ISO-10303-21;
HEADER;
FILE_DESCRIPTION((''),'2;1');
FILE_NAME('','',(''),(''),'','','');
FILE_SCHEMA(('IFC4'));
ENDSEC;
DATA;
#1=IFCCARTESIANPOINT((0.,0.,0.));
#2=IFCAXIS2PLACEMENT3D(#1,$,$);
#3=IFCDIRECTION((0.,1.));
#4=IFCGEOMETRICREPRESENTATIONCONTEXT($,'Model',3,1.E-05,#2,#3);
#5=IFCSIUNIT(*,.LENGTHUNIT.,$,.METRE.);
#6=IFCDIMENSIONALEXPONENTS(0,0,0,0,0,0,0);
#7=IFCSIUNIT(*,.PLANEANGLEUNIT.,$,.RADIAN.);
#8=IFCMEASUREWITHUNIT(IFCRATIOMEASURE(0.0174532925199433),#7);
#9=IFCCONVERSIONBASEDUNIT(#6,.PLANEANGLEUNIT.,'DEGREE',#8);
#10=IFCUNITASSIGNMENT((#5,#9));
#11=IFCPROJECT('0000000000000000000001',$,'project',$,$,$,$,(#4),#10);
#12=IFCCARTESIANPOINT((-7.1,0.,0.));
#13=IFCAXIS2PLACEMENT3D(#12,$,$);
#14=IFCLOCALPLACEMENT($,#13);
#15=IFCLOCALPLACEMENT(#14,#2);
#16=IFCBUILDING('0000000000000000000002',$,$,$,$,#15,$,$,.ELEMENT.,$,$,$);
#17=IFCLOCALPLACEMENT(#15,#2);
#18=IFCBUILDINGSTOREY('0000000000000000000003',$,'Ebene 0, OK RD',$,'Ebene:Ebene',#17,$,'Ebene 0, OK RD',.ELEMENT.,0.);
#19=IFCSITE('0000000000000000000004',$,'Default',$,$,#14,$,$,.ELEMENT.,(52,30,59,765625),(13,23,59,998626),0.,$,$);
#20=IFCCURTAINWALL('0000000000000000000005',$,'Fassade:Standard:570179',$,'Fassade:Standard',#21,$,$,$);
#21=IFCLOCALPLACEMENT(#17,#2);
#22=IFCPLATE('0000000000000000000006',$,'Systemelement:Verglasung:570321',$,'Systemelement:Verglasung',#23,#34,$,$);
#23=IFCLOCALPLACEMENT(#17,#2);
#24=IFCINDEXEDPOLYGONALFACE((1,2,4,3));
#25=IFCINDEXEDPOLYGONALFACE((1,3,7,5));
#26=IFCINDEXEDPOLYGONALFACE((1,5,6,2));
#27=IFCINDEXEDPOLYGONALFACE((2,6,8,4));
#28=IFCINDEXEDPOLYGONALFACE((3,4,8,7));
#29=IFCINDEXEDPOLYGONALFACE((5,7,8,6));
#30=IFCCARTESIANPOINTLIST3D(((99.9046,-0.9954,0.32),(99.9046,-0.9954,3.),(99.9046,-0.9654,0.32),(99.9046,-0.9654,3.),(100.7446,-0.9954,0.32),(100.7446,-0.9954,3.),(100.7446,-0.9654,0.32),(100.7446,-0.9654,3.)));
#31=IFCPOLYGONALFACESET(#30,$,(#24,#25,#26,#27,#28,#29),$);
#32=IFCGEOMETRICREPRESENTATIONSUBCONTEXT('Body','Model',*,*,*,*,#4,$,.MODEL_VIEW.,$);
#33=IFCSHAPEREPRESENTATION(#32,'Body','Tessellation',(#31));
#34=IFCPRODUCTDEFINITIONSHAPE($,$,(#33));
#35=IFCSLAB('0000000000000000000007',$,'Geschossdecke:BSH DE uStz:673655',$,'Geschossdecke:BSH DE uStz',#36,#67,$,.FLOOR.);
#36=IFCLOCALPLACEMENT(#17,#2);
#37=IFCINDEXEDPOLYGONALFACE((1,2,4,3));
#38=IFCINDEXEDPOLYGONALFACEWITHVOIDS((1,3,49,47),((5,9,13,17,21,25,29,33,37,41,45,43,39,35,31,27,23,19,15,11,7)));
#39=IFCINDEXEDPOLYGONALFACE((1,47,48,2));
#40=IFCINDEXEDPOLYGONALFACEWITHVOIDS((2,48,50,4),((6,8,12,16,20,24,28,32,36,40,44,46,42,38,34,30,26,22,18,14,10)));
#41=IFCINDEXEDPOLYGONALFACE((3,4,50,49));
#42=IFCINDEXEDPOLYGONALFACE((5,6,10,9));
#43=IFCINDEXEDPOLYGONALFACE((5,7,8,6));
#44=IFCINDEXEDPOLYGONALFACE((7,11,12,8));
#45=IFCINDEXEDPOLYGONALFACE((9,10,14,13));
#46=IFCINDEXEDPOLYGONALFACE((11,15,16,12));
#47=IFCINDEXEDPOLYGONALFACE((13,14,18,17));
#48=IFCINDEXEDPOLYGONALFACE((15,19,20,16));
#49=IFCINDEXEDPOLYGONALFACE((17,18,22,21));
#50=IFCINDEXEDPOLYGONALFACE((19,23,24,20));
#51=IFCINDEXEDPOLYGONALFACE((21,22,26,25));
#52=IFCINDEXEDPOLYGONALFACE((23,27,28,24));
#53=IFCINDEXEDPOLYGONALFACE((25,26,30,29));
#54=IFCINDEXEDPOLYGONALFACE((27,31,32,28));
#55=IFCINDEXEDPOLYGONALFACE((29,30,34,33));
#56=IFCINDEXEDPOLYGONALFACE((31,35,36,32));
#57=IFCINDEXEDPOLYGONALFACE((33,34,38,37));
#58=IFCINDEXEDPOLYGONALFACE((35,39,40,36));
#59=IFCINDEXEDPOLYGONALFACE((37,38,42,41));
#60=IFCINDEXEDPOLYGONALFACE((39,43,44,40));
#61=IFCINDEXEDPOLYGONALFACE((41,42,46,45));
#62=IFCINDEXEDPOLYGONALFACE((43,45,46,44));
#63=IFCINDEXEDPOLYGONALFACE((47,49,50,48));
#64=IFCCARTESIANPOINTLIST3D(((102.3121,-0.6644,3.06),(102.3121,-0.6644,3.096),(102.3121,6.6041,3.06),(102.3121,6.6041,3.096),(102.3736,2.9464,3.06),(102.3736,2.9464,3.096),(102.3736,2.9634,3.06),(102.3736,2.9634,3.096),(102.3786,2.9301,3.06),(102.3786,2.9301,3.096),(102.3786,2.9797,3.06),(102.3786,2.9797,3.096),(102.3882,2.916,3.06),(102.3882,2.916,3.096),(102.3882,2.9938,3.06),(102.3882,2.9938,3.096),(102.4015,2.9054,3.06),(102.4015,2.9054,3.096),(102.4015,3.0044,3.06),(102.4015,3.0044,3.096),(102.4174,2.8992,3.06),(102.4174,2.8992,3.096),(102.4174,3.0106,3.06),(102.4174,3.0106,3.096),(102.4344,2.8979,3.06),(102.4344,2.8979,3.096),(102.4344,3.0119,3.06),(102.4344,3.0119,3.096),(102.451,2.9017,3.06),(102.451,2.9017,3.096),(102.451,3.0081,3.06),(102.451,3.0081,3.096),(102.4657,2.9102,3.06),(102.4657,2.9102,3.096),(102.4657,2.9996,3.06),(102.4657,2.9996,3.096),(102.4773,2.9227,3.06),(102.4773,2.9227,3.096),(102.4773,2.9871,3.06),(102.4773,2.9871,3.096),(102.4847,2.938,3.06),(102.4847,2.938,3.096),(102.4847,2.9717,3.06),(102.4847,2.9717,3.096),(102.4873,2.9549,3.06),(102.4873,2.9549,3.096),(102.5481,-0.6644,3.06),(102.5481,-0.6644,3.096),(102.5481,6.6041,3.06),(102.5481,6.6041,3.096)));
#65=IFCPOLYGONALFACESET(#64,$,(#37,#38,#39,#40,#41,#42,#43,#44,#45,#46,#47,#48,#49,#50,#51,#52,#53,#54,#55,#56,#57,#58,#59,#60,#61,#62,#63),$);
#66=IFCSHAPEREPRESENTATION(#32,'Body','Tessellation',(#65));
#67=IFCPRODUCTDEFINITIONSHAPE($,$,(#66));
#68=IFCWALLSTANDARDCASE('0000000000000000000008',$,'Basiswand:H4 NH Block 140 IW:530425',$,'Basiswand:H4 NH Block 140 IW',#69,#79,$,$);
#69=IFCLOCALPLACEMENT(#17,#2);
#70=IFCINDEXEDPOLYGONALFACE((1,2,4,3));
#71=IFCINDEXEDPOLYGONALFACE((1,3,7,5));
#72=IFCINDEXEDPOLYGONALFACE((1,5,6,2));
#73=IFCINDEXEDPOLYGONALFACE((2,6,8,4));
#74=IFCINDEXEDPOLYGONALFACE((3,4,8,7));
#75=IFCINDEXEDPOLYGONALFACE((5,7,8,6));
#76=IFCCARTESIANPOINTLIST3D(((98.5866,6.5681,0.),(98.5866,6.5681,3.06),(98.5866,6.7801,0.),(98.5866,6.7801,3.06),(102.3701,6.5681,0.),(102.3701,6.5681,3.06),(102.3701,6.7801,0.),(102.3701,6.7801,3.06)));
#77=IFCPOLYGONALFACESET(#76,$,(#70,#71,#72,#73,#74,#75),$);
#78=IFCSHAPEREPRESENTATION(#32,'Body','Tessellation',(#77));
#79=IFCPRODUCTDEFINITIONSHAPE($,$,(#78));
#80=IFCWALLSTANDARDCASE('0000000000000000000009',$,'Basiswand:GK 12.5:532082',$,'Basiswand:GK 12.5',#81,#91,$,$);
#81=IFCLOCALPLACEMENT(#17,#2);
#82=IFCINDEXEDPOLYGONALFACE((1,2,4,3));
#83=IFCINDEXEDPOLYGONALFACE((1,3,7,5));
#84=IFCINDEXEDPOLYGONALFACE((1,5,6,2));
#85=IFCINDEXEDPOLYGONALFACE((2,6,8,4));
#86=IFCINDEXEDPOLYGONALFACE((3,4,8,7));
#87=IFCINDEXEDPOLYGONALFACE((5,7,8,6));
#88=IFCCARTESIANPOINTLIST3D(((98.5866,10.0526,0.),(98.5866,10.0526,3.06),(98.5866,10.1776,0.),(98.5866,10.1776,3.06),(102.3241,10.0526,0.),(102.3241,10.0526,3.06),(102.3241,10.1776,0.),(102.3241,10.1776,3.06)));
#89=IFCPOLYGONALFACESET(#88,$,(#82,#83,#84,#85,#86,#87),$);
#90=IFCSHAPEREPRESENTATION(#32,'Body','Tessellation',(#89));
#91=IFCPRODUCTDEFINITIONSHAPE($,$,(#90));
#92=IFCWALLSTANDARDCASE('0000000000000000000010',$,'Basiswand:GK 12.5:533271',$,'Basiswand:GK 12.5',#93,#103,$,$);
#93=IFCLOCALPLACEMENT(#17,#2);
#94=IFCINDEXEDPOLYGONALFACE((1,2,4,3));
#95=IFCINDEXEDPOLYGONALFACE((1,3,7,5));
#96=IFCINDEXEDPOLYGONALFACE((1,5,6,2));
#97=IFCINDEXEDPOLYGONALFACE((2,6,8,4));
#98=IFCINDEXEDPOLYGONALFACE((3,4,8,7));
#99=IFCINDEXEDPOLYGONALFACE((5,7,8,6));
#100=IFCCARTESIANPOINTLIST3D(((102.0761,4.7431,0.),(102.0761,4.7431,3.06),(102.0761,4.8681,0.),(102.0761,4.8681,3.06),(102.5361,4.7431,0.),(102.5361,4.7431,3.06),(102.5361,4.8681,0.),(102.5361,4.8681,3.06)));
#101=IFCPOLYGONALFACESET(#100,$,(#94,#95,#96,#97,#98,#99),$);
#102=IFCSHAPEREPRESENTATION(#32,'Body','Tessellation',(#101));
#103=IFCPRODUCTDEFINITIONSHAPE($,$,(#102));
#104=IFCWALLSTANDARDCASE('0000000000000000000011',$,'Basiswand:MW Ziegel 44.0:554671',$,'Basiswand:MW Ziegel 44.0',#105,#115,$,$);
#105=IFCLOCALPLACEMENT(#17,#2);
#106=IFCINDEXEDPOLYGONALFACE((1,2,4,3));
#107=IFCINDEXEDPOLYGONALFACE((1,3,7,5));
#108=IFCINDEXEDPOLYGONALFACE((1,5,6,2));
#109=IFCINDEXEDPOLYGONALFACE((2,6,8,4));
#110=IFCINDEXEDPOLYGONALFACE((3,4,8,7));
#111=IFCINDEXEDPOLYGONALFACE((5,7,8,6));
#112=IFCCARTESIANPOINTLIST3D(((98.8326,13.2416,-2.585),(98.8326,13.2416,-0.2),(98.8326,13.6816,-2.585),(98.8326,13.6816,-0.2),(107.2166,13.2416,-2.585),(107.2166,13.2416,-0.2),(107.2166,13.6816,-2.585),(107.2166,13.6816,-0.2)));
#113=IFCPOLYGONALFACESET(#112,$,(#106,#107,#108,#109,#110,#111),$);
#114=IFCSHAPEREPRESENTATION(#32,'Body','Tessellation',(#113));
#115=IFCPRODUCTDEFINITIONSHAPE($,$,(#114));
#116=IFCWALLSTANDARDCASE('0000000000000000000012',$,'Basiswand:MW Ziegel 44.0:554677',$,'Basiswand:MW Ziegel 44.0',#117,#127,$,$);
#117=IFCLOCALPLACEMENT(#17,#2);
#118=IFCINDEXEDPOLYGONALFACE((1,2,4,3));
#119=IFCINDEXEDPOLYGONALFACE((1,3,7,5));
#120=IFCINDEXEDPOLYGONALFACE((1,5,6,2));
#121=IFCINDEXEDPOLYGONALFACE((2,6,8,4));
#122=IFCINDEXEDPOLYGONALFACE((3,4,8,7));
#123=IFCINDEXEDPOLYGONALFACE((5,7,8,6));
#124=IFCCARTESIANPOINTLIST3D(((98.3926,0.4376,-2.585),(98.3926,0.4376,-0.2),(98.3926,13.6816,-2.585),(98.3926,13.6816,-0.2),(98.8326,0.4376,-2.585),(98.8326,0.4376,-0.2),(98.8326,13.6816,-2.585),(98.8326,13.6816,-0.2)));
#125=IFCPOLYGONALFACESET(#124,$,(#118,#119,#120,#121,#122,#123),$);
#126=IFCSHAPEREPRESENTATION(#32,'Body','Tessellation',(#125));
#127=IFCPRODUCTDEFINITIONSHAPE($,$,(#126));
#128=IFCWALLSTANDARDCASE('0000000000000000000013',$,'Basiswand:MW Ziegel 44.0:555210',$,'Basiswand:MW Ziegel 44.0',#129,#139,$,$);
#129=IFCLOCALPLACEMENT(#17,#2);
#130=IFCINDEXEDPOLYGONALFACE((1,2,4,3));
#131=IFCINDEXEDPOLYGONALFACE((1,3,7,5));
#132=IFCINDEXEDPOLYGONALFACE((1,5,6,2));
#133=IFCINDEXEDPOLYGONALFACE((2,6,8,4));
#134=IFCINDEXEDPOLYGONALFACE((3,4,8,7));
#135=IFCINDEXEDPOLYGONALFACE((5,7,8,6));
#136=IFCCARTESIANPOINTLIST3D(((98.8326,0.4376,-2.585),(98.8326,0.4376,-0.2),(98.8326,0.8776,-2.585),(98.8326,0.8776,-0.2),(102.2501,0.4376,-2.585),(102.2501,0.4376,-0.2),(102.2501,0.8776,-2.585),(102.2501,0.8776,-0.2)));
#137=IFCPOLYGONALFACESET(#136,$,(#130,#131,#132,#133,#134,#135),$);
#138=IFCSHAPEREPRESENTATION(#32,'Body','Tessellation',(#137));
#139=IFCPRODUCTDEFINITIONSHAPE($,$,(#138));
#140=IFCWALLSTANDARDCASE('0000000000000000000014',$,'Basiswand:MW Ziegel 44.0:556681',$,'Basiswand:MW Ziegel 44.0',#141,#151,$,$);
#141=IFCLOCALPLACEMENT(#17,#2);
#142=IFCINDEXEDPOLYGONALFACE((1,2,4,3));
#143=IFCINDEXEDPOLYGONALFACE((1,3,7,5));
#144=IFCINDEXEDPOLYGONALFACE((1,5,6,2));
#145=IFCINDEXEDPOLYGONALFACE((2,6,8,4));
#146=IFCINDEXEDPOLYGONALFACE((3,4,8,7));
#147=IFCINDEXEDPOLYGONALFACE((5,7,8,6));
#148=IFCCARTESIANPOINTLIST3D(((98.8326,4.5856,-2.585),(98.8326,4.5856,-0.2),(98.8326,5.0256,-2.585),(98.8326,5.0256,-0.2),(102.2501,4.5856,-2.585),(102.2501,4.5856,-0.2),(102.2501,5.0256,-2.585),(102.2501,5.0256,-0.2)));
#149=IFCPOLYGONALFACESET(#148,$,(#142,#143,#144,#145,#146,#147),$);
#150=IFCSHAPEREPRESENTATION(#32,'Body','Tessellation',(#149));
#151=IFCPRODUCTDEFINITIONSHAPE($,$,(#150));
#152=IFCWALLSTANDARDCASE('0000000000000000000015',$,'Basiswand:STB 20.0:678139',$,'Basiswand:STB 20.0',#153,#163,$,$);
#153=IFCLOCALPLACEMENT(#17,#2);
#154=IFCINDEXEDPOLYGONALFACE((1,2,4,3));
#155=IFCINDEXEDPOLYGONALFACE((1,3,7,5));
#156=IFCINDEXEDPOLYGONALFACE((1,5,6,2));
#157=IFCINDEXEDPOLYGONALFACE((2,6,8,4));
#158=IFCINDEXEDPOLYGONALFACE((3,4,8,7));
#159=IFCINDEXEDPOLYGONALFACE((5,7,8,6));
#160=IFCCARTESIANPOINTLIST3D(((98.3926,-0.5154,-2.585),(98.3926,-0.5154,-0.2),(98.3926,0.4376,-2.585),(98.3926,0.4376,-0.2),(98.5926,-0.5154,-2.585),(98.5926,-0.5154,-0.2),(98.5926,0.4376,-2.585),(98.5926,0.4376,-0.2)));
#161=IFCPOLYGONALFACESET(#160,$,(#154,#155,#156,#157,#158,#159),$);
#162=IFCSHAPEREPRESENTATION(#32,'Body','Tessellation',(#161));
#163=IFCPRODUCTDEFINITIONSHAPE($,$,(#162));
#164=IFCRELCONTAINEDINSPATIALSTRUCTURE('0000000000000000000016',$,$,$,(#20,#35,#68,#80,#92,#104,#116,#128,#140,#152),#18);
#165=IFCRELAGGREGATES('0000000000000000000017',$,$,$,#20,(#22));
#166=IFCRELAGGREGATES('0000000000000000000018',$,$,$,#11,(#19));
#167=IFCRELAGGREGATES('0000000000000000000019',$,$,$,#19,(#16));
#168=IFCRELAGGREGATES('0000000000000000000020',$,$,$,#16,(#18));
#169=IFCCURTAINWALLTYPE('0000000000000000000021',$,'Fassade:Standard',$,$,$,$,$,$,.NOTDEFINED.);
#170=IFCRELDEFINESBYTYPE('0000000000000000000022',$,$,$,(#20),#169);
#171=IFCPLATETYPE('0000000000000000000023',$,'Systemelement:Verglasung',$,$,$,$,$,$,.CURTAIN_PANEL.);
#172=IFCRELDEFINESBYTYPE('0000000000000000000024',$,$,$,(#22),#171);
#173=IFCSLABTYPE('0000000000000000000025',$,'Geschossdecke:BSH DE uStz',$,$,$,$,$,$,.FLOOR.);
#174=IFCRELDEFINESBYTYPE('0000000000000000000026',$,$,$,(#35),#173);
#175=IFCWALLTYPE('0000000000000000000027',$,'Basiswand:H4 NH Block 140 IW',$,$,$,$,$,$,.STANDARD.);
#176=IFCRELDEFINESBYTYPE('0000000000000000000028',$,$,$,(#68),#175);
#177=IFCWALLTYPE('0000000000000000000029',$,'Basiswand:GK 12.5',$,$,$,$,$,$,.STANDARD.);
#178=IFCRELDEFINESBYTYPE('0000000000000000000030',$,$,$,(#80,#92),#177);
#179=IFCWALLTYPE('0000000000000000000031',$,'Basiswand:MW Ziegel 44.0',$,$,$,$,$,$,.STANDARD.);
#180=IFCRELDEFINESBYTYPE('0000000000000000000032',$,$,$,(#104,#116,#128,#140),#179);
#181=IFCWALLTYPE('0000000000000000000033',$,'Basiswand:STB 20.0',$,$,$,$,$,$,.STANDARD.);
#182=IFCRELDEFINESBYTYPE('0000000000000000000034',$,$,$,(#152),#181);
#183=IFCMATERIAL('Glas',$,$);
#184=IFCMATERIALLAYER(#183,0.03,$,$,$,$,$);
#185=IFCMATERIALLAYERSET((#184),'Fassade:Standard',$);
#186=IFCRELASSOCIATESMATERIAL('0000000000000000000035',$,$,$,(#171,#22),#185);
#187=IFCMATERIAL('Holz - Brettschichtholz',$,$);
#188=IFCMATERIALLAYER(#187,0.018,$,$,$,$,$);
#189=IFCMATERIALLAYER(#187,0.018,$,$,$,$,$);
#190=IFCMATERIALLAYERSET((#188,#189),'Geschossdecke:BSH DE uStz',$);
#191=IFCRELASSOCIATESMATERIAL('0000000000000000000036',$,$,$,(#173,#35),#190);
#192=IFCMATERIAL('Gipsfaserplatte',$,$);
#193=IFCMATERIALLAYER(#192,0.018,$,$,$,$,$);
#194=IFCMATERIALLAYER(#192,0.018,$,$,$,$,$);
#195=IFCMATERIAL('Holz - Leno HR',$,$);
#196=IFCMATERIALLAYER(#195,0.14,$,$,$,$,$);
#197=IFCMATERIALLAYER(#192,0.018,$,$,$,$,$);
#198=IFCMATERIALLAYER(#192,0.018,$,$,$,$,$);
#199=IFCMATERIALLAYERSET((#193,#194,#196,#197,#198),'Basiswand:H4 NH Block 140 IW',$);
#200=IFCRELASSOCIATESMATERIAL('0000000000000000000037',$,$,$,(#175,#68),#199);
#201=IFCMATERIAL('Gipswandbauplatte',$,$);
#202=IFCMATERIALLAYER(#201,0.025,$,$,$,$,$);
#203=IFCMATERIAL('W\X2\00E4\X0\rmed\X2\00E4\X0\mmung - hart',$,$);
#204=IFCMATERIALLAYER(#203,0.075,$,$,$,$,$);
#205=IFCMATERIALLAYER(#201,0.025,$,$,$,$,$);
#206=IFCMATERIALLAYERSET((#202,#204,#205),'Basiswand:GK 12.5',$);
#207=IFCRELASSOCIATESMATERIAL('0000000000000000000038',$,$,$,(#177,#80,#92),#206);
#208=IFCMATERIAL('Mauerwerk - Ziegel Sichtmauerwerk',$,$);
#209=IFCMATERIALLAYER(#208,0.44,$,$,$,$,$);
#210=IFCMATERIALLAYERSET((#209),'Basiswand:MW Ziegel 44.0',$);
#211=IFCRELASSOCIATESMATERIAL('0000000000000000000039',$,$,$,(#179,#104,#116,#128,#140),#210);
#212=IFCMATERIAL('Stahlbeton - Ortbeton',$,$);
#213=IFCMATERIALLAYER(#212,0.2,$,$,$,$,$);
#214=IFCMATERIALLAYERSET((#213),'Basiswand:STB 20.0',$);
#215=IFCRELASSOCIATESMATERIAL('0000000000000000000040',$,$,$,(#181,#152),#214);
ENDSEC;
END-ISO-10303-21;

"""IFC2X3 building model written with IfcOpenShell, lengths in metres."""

from ifc_helpers import new_model, entity, si_unit, converted_unit, direction, frame, frame_2d, origin, origin_2d_with_axis, place, context, subcontext, project, spatial, rectangle, circle, extrude, source, transform, mapped, material, layer, layer_set, layer_usage, type_object, type_shapes, element, aggregate, save


model = new_model("IFC2X3")

# Units and contexts
model_context = context("Model", 3, precision=1e-05, world=origin(), true_north=direction((0.0, 1.0)))
body_context = subcontext(model_context, "Body", "Model", "MODEL_VIEW")
ifc_project = project(units=[si_unit("LENGTHUNIT", "METRE"), converted_unit("PLANEANGLEUNIT", "DEGREE", entity("IfcRatioMeasure", 0.0174532925199433), si_unit("PLANEANGLEUNIT", "RADIAN"), dimensions=[0, 0, 0, 0, 0, 0, 0])], contexts=[model_context])

# Site, building, storey
site_placement = place(None, frame((-7.1, 0.0, 0.0)))
site = spatial("IfcSite", under=ifc_project, at=site_placement, Name="Default", CompositionType="ELEMENT", RefLatitude=(52, 30, 59, 765625), RefLongitude=(13, 23, 59, 998626), RefElevation=0.0)
building_placement = place(site_placement, origin())
building = spatial("IfcBuilding", under=site, at=building_placement, CompositionType="ELEMENT")
storey_placement = place(building_placement, origin())
storey = spatial("IfcBuildingStorey", under=building, at=storey_placement, Name="Ebene 0, OK RD", ObjectType="Ebene:Ebene", LongName="Ebene 0, OK RD", CompositionType="ELEMENT", Elevation=0.0)

# Curtain wall, plate
curtain_wall_type = type_object("IfcCurtainWallType", Name="Fassade:Standard", PredefinedType="NOTDEFINED")
curtain_wall_placement = place(storey_placement, origin())
curtain_wall = element("IfcCurtainWall", 1, at=curtain_wall_placement, inside=storey, type_object=curtain_wall_type, Name="Fassade:Standard:570179", ObjectType="Fassade:Standard")
ifc_material_1 = material(Name="Glas")
ifc_layer_1 = layer(ifc_material_1, 0.03)
ifc_layer_set_1 = layer_set([ifc_layer_1], Name="Fassade:Standard")
ifc_layer_usage_1 = layer_usage(ifc_layer_set_1, "AXIS3", "POSITIVE", 0.0)
plate_type_1 = type_object("IfcPlateType", Name="Systemelement:Verglasung", PredefinedType="CURTAIN_PANEL", material=ifc_layer_set_1)
shared_shape_1 = source(origin(), body_context, "Body", "SweptSolid", [
    extrude(rectangle(XDim=0.03, YDim=0.84, at=origin_2d_with_axis()), frame((0.0, 0.0, 0.0), z_axis=(0.0, 0.0, 1.0), x_axis=(0.0, 1.0, 0.0)), (0.0, 0.0, 1.0), 2.68),
])
type_shapes(plate_type_1, [shared_shape_1])
plate_1_placement = place(curtain_wall_placement, frame((100.3246, -0.9804, 0.32)))
plate_1 = element("IfcPlate", 2, at=plate_1_placement, type_object=plate_type_1, material=ifc_layer_usage_1, Name="Systemelement:Verglasung:570321", ObjectType="Systemelement:Verglasung", context=body_context, shape_type="MappedRepresentation", body=[
    mapped(shared_shape_1, transform((0.0, 0.0, 0.0), scale=1.0)),
])
aggregate(curtain_wall, [plate_1])

# Slab, opening
ifc_material_2 = material(Name="Holz - Brettschichtholz")
ifc_layer_2 = layer(ifc_material_2, 0.018)
ifc_layer_3 = layer(ifc_material_2, 0.018)
ifc_layer_set_2 = layer_set([ifc_layer_2, ifc_layer_3], Name="Geschossdecke:BSH DE uStz")
ifc_layer_usage_2 = layer_usage(ifc_layer_set_2, "AXIS3", "POSITIVE", 0.0)
slab_type_1 = type_object("IfcSlabType", Name="Geschossdecke:BSH DE uStz", PredefinedType="FLOOR", material=ifc_layer_set_2)
slab_placement = place(storey_placement, frame((102.3121, -0.6644, 3.06)))
slab = element("IfcSlab", 3, at=slab_placement, inside=storey, type_object=slab_type_1, material=ifc_layer_usage_2, Name="Geschossdecke:BSH DE uStz:673655", ObjectType="Geschossdecke:BSH DE uStz", PredefinedType="FLOOR", context=body_context, shape_type="SweptSolid", body=[
    extrude(rectangle(XDim=0.236, YDim=7.2685, at=origin_2d_with_axis()), frame((0.118, 3.6343, 0.036), z_axis=(0.0, 0.0, -1.0), x_axis=(-1.0, 0.0, 0.0)), (0.0, 0.0, 1.0), 0.036),
])
opening_1_placement = place(slab_placement, frame((0.118, 3.6193, 0.036)))
element("IfcOpeningElement", 4, at=opening_1_placement, cuts=slab, ObjectType="Opening", context=body_context, shape_type="SweptSolid", body=[
    extrude(circle(Radius=0.0571, at=origin_2d_with_axis()), frame((0.0, 0.0, 0.0), z_axis=(0.0, 0.0, -1.0), x_axis=(1.0, 0.0, 0.0)), (0.0, 0.0, 1.0), 0.036),
])

# Walls
ifc_material_3 = material(Name="Gipsfaserplatte")
ifc_layer_4 = layer(ifc_material_3, 0.018)
ifc_layer_5 = layer(ifc_material_3, 0.018)
ifc_material_4 = material(Name="Holz - Leno HR")
ifc_layer_6 = layer(ifc_material_4, 0.14)
ifc_layer_7 = layer(ifc_material_3, 0.018)
ifc_layer_8 = layer(ifc_material_3, 0.018)
ifc_layer_set_3 = layer_set([ifc_layer_4, ifc_layer_5, ifc_layer_6, ifc_layer_7, ifc_layer_8], Name="Basiswand:H4 NH Block 140 IW")
ifc_layer_usage_3 = layer_usage(ifc_layer_set_3, "AXIS2", "NEGATIVE", 0.106)
wall_type_1 = type_object("IfcWallType", Name="Basiswand:H4 NH Block 140 IW", PredefinedType="STANDARD", material=ifc_layer_set_3)
wall_1_placement = place(storey_placement, frame((98.5866, 6.6741, 0.0)))
element("IfcWallStandardCase", 5, at=wall_1_placement, inside=storey, type_object=wall_type_1, material=ifc_layer_usage_3, Name="Basiswand:H4 NH Block 140 IW:530425", ObjectType="Basiswand:H4 NH Block 140 IW", context=body_context, shape_type="SweptSolid", body=[
    extrude(rectangle(XDim=3.7835, YDim=0.212, at=frame_2d((1.8918, 0.0), x_axis=(-1.0, 0.0))), origin(), (0.0, 0.0, 1.0), 3.06),
])
ifc_material_5 = material(Name="Gipswandbauplatte")
ifc_layer_9 = layer(ifc_material_5, 0.025)
ifc_material_6 = material(Name="Wärmedämmung - hart")
ifc_layer_10 = layer(ifc_material_6, 0.075)
ifc_layer_11 = layer(ifc_material_5, 0.025)
ifc_layer_set_4 = layer_set([ifc_layer_9, ifc_layer_10, ifc_layer_11], Name="Basiswand:GK 12.5")
ifc_layer_usage_4 = layer_usage(ifc_layer_set_4, "AXIS2", "NEGATIVE", 0.0625)
wall_type_2 = type_object("IfcWallType", Name="Basiswand:GK 12.5", PredefinedType="STANDARD", material=ifc_layer_set_4)
wall_2_placement = place(storey_placement, frame((98.5866, 10.1151, 0.0)))
element("IfcWallStandardCase", 6, at=wall_2_placement, inside=storey, type_object=wall_type_2, material=ifc_layer_usage_4, Name="Basiswand:GK 12.5:532082", ObjectType="Basiswand:GK 12.5", context=body_context, shape_type="SweptSolid", body=[
    extrude(rectangle(XDim=3.7375, YDim=0.125, at=frame_2d((1.8687, 0.0), x_axis=(-1.0, 0.0))), origin(), (0.0, 0.0, 1.0), 3.06),
])
ifc_layer_usage_5 = layer_usage(ifc_layer_set_4, "AXIS2", "NEGATIVE", 0.0625)
wall_3_placement = place(storey_placement, frame((102.0761, 4.8056, 0.0)))
element("IfcWallStandardCase", 7, at=wall_3_placement, inside=storey, type_object=wall_type_2, material=ifc_layer_usage_5, Name="Basiswand:GK 12.5:533271", ObjectType="Basiswand:GK 12.5", context=body_context, shape_type="SweptSolid", body=[
    extrude(rectangle(XDim=0.46, YDim=0.125, at=frame_2d((0.23, 0.0), x_axis=(-1.0, 0.0))), origin(), (0.0, 0.0, 1.0), 3.06),
])
ifc_material_7 = material(Name="Mauerwerk - Ziegel Sichtmauerwerk")
ifc_layer_12 = layer(ifc_material_7, 0.44)
ifc_layer_set_5 = layer_set([ifc_layer_12], Name="Basiswand:MW Ziegel 44.0")
ifc_layer_usage_6 = layer_usage(ifc_layer_set_5, "AXIS2", "NEGATIVE", 0.22)
wall_type_3 = type_object("IfcWallType", Name="Basiswand:MW Ziegel 44.0", PredefinedType="STANDARD", material=ifc_layer_set_5)
wall_4_placement = place(storey_placement, frame((98.8326, 13.4616, -2.585)))
element("IfcWallStandardCase", 8, at=wall_4_placement, inside=storey, type_object=wall_type_3, material=ifc_layer_usage_6, Name="Basiswand:MW Ziegel 44.0:554671", ObjectType="Basiswand:MW Ziegel 44.0", context=body_context, shape_type="SweptSolid", body=[
    extrude(rectangle(XDim=8.384, YDim=0.44, at=frame_2d((4.192, 0.0), x_axis=(-1.0, 0.0))), origin(), (0.0, 0.0, 1.0), 2.385),
])
ifc_layer_usage_7 = layer_usage(ifc_layer_set_5, "AXIS2", "NEGATIVE", 0.22)
wall_5_placement = place(storey_placement, frame((98.6126, 0.4376, -2.585), z_axis=(0.0, 0.0, 1.0), x_axis=(0.0, 1.0, 0.0)))
element("IfcWallStandardCase", 9, at=wall_5_placement, inside=storey, type_object=wall_type_3, material=ifc_layer_usage_7, Name="Basiswand:MW Ziegel 44.0:554677", ObjectType="Basiswand:MW Ziegel 44.0", context=body_context, shape_type="SweptSolid", body=[
    extrude(rectangle(XDim=13.244, YDim=0.44, at=frame_2d((6.622, 0.0), x_axis=(-1.0, 0.0))), origin(), (0.0, 0.0, 1.0), 2.385),
])
ifc_layer_usage_8 = layer_usage(ifc_layer_set_5, "AXIS2", "NEGATIVE", 0.22)
wall_6_placement = place(storey_placement, frame((102.2501, 0.6576, -2.585), z_axis=(0.0, 0.0, 1.0), x_axis=(-1.0, 0.0, 0.0)))
element("IfcWallStandardCase", 10, at=wall_6_placement, inside=storey, type_object=wall_type_3, material=ifc_layer_usage_8, Name="Basiswand:MW Ziegel 44.0:555210", ObjectType="Basiswand:MW Ziegel 44.0", context=body_context, shape_type="SweptSolid", body=[
    extrude(rectangle(XDim=3.4175, YDim=0.44, at=frame_2d((1.7087, 0.0), x_axis=(-1.0, 0.0))), origin(), (0.0, 0.0, 1.0), 2.385),
])
ifc_layer_usage_9 = layer_usage(ifc_layer_set_5, "AXIS2", "NEGATIVE", 0.22)
wall_7_placement = place(storey_placement, frame((98.8326, 4.8056, -2.585)))
element("IfcWallStandardCase", 11, at=wall_7_placement, inside=storey, type_object=wall_type_3, material=ifc_layer_usage_9, Name="Basiswand:MW Ziegel 44.0:556681", ObjectType="Basiswand:MW Ziegel 44.0", context=body_context, shape_type="SweptSolid", body=[
    extrude(rectangle(XDim=3.4175, YDim=0.44, at=frame_2d((1.7087, 0.0), x_axis=(-1.0, 0.0))), origin(), (0.0, 0.0, 1.0), 2.385),
])
ifc_material_8 = material(Name="Stahlbeton - Ortbeton")
ifc_layer_13 = layer(ifc_material_8, 0.2)
ifc_layer_set_6 = layer_set([ifc_layer_13], Name="Basiswand:STB 20.0")
ifc_layer_usage_10 = layer_usage(ifc_layer_set_6, "AXIS2", "NEGATIVE", 0.1)
wall_type_4 = type_object("IfcWallType", Name="Basiswand:STB 20.0", PredefinedType="STANDARD", material=ifc_layer_set_6)
wall_8_placement = place(storey_placement, frame((98.4926, -0.5154, -2.585), z_axis=(0.0, 0.0, 1.0), x_axis=(0.0, 1.0, 0.0)))
element("IfcWallStandardCase", 12, at=wall_8_placement, inside=storey, type_object=wall_type_4, material=ifc_layer_usage_10, Name="Basiswand:STB 20.0:678139", ObjectType="Basiswand:STB 20.0", context=body_context, shape_type="SweptSolid", body=[
    extrude(rectangle(XDim=0.953, YDim=0.2, at=frame_2d((0.4765, 0.0), x_axis=(-1.0, 0.0))), origin(), (0.0, 0.0, 1.0), 2.385),
])

save(model, "model.ifc")
